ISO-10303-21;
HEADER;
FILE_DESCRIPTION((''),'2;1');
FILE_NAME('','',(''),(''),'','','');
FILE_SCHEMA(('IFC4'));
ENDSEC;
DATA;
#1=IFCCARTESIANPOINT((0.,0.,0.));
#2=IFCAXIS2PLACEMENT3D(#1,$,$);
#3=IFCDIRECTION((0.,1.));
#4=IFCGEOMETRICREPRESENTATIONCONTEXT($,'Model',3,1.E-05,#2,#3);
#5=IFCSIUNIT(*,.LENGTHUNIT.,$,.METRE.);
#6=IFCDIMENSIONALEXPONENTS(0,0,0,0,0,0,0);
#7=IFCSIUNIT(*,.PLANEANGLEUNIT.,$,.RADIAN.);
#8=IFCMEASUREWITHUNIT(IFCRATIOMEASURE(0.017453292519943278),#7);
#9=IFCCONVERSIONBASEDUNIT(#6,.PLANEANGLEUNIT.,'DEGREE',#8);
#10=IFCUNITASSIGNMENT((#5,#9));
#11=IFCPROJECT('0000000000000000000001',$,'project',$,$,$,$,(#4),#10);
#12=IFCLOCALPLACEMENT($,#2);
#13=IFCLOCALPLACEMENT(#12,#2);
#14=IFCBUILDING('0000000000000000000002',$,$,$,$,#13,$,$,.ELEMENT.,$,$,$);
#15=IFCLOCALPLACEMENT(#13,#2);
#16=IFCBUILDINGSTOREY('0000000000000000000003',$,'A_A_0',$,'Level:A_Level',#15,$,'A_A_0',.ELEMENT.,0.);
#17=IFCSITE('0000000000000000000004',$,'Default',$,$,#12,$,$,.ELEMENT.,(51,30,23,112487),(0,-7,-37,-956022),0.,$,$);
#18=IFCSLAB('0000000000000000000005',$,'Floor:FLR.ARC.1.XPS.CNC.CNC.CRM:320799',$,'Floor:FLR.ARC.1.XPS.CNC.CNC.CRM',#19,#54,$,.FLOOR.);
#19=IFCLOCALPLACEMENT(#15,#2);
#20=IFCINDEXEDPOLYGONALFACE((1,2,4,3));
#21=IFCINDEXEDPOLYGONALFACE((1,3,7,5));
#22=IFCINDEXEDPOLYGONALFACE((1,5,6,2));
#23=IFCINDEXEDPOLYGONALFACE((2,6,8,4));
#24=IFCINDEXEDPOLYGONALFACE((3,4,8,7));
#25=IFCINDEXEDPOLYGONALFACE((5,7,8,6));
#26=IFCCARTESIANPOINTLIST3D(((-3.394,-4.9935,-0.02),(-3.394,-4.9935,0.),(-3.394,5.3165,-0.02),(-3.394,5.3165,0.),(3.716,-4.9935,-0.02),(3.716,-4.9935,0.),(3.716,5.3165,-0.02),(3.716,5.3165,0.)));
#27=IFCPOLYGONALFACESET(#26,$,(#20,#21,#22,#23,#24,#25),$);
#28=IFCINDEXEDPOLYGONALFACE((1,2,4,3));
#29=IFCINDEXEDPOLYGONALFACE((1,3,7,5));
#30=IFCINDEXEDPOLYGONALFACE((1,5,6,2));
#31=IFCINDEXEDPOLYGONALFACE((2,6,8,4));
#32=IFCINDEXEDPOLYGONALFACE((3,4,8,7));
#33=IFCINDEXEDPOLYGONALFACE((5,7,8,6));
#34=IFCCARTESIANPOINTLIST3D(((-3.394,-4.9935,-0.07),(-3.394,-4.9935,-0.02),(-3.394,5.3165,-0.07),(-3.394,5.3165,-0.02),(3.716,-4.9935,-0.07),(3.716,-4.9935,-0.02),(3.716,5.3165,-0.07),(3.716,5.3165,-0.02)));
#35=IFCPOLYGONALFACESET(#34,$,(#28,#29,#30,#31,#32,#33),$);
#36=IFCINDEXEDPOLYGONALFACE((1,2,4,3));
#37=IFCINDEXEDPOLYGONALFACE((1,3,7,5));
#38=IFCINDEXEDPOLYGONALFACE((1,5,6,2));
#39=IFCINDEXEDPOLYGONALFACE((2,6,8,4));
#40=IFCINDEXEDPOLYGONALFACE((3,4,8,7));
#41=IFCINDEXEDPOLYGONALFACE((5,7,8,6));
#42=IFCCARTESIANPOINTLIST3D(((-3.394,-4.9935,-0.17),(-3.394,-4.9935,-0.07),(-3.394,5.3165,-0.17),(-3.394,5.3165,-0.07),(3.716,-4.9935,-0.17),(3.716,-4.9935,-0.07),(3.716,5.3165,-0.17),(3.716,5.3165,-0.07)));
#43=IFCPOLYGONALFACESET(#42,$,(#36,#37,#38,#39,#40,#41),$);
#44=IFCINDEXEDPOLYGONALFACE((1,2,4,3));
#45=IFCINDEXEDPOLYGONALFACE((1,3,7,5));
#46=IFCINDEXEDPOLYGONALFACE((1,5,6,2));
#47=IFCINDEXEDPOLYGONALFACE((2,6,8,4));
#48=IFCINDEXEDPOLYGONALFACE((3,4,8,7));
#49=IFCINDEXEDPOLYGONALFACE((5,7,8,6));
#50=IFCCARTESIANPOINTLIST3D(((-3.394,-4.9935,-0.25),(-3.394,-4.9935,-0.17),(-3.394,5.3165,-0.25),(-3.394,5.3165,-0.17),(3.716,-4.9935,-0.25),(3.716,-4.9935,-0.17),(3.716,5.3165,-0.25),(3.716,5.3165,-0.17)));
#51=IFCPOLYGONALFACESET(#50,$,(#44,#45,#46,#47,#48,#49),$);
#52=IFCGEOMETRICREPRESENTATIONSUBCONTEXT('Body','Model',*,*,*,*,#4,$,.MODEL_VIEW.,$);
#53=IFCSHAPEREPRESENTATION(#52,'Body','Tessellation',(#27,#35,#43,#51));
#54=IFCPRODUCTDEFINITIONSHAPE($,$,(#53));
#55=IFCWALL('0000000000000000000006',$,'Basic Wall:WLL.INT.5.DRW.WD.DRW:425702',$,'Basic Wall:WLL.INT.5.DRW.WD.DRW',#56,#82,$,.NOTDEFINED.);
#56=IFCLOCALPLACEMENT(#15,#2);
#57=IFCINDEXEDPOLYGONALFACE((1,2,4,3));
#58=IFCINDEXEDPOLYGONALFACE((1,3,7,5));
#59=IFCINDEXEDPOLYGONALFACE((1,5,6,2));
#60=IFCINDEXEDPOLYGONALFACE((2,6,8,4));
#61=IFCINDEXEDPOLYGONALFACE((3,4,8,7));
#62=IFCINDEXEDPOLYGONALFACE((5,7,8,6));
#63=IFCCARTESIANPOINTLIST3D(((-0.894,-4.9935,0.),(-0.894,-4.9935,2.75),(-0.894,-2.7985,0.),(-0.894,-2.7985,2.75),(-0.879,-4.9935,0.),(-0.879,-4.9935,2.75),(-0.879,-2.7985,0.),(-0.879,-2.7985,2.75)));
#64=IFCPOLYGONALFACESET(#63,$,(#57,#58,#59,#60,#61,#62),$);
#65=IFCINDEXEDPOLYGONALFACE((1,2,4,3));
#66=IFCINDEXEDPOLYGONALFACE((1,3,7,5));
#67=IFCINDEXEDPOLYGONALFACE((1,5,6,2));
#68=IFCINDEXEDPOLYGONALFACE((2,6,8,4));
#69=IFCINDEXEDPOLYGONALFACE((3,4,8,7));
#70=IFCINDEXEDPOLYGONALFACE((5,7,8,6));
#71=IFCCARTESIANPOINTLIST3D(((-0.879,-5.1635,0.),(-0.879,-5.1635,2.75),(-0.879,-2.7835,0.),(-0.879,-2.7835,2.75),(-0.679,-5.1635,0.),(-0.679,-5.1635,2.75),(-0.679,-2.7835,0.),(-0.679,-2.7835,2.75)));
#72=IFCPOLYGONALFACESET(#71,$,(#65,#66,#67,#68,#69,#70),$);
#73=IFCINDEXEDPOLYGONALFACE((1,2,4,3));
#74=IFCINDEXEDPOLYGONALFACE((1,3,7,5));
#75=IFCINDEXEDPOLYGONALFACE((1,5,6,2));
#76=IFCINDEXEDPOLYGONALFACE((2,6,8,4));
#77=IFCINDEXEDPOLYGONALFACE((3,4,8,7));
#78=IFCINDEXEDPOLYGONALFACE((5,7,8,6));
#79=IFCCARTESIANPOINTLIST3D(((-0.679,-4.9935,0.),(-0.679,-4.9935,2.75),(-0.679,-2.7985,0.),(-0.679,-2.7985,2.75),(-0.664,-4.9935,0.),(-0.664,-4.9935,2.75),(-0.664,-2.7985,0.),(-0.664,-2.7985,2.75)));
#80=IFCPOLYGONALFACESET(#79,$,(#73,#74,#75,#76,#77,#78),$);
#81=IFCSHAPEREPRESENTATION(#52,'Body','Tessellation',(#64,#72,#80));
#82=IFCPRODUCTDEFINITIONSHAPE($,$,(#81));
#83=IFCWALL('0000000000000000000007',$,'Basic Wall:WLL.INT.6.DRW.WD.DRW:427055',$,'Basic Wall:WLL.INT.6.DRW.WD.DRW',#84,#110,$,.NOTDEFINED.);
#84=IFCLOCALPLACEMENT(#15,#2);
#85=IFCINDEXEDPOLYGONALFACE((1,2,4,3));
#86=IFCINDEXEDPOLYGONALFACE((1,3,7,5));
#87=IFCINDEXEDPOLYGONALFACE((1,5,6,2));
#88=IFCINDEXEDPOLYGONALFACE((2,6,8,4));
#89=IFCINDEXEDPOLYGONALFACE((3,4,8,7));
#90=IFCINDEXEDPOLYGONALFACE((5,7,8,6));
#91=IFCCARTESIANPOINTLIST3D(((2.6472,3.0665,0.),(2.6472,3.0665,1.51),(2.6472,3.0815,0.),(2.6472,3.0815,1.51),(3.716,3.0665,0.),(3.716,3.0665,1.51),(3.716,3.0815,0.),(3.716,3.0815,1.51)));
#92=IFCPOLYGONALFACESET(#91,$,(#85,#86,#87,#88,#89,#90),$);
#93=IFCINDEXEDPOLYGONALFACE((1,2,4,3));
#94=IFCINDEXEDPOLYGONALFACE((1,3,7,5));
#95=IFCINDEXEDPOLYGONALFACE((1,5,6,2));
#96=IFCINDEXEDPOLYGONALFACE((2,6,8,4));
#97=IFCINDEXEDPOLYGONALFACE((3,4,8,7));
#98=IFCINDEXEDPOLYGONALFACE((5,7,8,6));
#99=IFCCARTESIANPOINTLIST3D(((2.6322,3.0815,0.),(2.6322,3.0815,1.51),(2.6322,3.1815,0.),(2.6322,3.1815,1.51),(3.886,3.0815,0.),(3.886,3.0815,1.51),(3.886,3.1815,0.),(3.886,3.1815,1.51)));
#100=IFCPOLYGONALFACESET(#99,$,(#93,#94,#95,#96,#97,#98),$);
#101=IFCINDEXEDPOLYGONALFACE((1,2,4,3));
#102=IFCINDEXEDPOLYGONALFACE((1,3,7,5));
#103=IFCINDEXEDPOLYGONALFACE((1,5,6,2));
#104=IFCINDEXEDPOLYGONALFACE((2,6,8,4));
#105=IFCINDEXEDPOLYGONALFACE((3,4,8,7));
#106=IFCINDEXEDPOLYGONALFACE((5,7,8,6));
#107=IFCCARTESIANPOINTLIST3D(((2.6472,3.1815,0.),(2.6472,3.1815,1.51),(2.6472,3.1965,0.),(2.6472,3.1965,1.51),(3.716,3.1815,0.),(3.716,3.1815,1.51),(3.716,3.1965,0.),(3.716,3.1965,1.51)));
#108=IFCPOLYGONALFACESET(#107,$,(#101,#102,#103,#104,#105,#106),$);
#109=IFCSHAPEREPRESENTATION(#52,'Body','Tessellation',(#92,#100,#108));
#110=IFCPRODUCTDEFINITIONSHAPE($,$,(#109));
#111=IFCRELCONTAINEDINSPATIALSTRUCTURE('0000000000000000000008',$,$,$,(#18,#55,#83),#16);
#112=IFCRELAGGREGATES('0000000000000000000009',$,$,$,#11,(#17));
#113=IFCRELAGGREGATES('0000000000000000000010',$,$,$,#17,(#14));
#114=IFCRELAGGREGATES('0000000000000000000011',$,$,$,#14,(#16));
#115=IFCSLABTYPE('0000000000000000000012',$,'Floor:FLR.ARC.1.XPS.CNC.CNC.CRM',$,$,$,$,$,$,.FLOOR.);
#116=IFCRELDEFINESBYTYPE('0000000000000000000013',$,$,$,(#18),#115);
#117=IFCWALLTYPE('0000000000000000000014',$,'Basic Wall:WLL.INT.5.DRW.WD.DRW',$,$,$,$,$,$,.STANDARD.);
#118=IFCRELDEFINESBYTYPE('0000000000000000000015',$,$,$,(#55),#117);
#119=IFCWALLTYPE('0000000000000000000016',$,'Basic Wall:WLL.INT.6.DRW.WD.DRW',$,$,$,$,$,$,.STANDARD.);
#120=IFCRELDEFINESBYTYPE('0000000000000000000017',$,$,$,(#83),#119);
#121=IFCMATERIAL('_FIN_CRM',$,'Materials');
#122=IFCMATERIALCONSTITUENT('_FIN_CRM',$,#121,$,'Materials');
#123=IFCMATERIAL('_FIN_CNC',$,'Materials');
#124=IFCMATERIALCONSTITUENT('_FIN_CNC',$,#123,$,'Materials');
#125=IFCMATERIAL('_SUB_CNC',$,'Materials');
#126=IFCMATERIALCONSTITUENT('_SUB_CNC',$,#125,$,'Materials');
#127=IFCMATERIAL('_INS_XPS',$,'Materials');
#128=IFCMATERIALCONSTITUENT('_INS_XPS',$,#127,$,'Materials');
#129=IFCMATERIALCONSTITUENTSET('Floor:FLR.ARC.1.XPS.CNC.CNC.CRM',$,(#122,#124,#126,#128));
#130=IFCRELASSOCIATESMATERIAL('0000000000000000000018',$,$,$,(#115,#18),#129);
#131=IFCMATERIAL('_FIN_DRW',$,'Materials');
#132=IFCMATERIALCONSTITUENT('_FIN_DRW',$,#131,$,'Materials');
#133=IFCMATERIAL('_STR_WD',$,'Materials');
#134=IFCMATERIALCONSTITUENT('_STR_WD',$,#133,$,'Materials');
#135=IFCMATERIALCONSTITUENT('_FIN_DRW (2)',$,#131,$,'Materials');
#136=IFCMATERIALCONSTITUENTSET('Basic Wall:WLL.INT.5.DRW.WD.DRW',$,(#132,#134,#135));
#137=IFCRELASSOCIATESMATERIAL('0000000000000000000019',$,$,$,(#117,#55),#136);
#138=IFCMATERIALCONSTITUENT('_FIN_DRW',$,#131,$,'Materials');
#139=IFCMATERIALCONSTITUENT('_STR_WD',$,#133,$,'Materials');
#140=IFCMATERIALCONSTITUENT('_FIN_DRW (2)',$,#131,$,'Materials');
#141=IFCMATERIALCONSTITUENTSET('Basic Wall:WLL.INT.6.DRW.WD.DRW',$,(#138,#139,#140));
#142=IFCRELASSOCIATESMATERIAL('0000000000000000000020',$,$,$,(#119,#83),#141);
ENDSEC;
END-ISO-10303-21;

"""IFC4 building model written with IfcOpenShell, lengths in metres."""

from ifc_helpers import new_model, entity, si_unit, converted_unit, direction, frame, origin, place, context, subcontext, project, spatial, indexed_curve, outline, extrude, material, constituent, constituent_set, type_object, element, save


model = new_model("IFC4")

# Units and contexts
model_context = context("Model", 3, precision=1e-05, world=origin(), true_north=direction((0.0, 1.0)))
body_context = subcontext(model_context, "Body", "Model", "MODEL_VIEW")
ifc_project = project(units=[si_unit("LENGTHUNIT", "METRE"), converted_unit("PLANEANGLEUNIT", "DEGREE", entity("IfcRatioMeasure", 0.017453292519943278), si_unit("PLANEANGLEUNIT", "RADIAN"), dimensions=[0, 0, 0, 0, 0, 0, 0])], contexts=[model_context])

# Site, building, storey
site_placement = place(None, origin())
site = spatial("IfcSite", under=ifc_project, at=site_placement, Name="Default", CompositionType="ELEMENT", RefLatitude=(51, 30, 23, 112487), RefLongitude=(0, -7, -37, -956022), RefElevation=0.0)
building_placement = place(site_placement, origin())
building = spatial("IfcBuilding", under=site, at=building_placement, CompositionType="ELEMENT")
storey_placement = place(building_placement, origin())
storey = spatial("IfcBuildingStorey", under=building, at=storey_placement, Name="A_A_0", ObjectType="Level:A_Level", LongName="A_A_0", CompositionType="ELEMENT", Elevation=0.0)

# Slab
ifc_material_1 = material(Name="_FIN_CRM", Category="Materials")
ifc_constituent_1 = constituent(ifc_material_1, Name="_FIN_CRM", Category="Materials")
ifc_material_2 = material(Name="_FIN_CNC", Category="Materials")
ifc_constituent_2 = constituent(ifc_material_2, Name="_FIN_CNC", Category="Materials")
ifc_material_3 = material(Name="_SUB_CNC", Category="Materials")
ifc_constituent_3 = constituent(ifc_material_3, Name="_SUB_CNC", Category="Materials")
ifc_material_4 = material(Name="_INS_XPS", Category="Materials")
ifc_constituent_4 = constituent(ifc_material_4, Name="_INS_XPS", Category="Materials")
ifc_constituent_set_1 = constituent_set(constituents=[ifc_constituent_1, ifc_constituent_2, ifc_constituent_3, ifc_constituent_4], Name="Floor:FLR.ARC.1.XPS.CNC.CNC.CRM")
slab_type = type_object("IfcSlabType", Name="Floor:FLR.ARC.1.XPS.CNC.CNC.CRM", PredefinedType="FLOOR", material=ifc_constituent_set_1)
slab_placement = place(storey_placement, origin())
element("IfcSlab", 1, at=slab_placement, inside=storey, type_object=slab_type, material=ifc_constituent_set_1, Name="Floor:FLR.ARC.1.XPS.CNC.CNC.CRM:320799", ObjectType="Floor:FLR.ARC.1.XPS.CNC.CNC.CRM", PredefinedType="FLOOR", context=body_context, shape_type="SweptSolid", body=[
    extrude(outline(indexed_curve([(-5.155, -3.555), (5.155, -3.555), (5.155, 3.555), (-5.155, 3.555), (-5.155, -3.555)], self_intersect=False)), frame((0.161, 0.1615, -0.02), z_axis=(0.0, 0.0, 1.0), x_axis=(0.0, 1.0, 0.0)), (0.0, 0.0, 1.0), 0.02),
    extrude(outline(indexed_curve([(-5.155, -3.555), (5.155, -3.555), (5.155, 3.555), (-5.155, 3.555), (-5.155, -3.555)], self_intersect=False)), frame((0.161, 0.1615, -0.07), z_axis=(0.0, 0.0, 1.0), x_axis=(0.0, 1.0, 0.0)), (0.0, 0.0, 1.0), 0.05),
    extrude(outline(indexed_curve([(-5.155, -3.555), (5.155, -3.555), (5.155, 3.555), (-5.155, 3.555), (-5.155, -3.555)], self_intersect=False)), frame((0.161, 0.1615, -0.17), z_axis=(0.0, 0.0, 1.0), x_axis=(0.0, 1.0, 0.0)), (0.0, 0.0, 1.0), 0.1),
    extrude(outline(indexed_curve([(-5.155, -3.555), (5.155, -3.555), (5.155, 3.555), (-5.155, 3.555), (-5.155, -3.555)], self_intersect=False)), frame((0.161, 0.1615, -0.25), z_axis=(0.0, 0.0, 1.0), x_axis=(0.0, 1.0, 0.0)), (0.0, 0.0, 1.0), 0.08),
])

# Wall
ifc_material_5 = material(Name="_FIN_DRW", Category="Materials")
ifc_constituent_5 = constituent(ifc_material_5, Name="_FIN_DRW", Category="Materials")
ifc_material_6 = material(Name="_STR_WD", Category="Materials")
ifc_constituent_6 = constituent(ifc_material_6, Name="_STR_WD", Category="Materials")
ifc_constituent_7 = constituent(ifc_material_5, Name="_FIN_DRW (2)", Category="Materials")
ifc_constituent_set_2 = constituent_set(constituents=[ifc_constituent_5, ifc_constituent_6, ifc_constituent_7], Name="Basic Wall:WLL.INT.5.DRW.WD.DRW")
wall_type_1 = type_object("IfcWallType", Name="Basic Wall:WLL.INT.5.DRW.WD.DRW", PredefinedType="STANDARD", material=ifc_constituent_set_2)
wall_1_placement = place(storey_placement, frame((-0.779, -2.7985, 0.0), z_axis=(0.0, 0.0, 1.0), x_axis=(0.0, -1.0, 0.0)))
element("IfcWall", 2, at=wall_1_placement, inside=storey, type_object=wall_type_1, material=ifc_constituent_set_2, Name="Basic Wall:WLL.INT.5.DRW.WD.DRW:425702", ObjectType="Basic Wall:WLL.INT.5.DRW.WD.DRW", PredefinedType="NOTDEFINED", context=body_context, shape_type="SweptSolid", body=[
    extrude(outline(indexed_curve([(-0.0075, -1.0975), (0.0075, -1.0975), (0.0075, 1.0975), (-0.0075, 1.0975), (-0.0075, -1.0975)], self_intersect=False)), frame((1.0975, -0.1075, 0.0), z_axis=(0.0, 0.0, 1.0), x_axis=(0.0, 1.0, 0.0)), (0.0, 0.0, 1.0), 2.75),
    extrude(outline(indexed_curve([(-1.19, -0.1), (1.19, -0.1), (1.19, 0.1), (-1.19, 0.1), (-1.19, -0.1)], self_intersect=False)), frame((1.175, 0.0, 0.0)), (0.0, 0.0, 1.0), 2.75),
    extrude(outline(indexed_curve([(-0.0075, -1.0975), (0.0075, -1.0975), (0.0075, 1.0975), (-0.0075, 1.0975), (-0.0075, -1.0975)], self_intersect=False)), frame((1.0975, 0.1075, 0.0), z_axis=(0.0, 0.0, 1.0), x_axis=(0.0, -1.0, 0.0)), (0.0, 0.0, 1.0), 2.75),
])

# Shared definitions
ifc_constituent_8 = constituent(ifc_material_5, Name="_FIN_DRW", Category="Materials")
ifc_constituent_9 = constituent(ifc_material_6, Name="_STR_WD", Category="Materials")
ifc_constituent_10 = constituent(ifc_material_5, Name="_FIN_DRW (2)", Category="Materials")
ifc_constituent_set_3 = constituent_set(constituents=[ifc_constituent_8, ifc_constituent_9, ifc_constituent_10], Name="Basic Wall:WLL.INT.6.DRW.WD.DRW")
wall_type_2 = type_object("IfcWallType", Name="Basic Wall:WLL.INT.6.DRW.WD.DRW", PredefinedType="STANDARD", material=ifc_constituent_set_3)

# Wall
wall_2_placement = place(storey_placement, frame((2.6472, 3.1315, 0.0)))
element("IfcWall", 3, at=wall_2_placement, inside=storey, type_object=wall_type_2, material=ifc_constituent_set_3, Name="Basic Wall:WLL.INT.6.DRW.WD.DRW:427055", ObjectType="Basic Wall:WLL.INT.6.DRW.WD.DRW", PredefinedType="NOTDEFINED", context=body_context, shape_type="SweptSolid", body=[
    extrude(outline(indexed_curve([(-0.0075, -0.5344), (0.0075, -0.5344), (0.0075, 0.5344), (-0.0075, 0.5344), (-0.0075, -0.5344)], self_intersect=False)), frame((0.5344, -0.0575, 0.0), z_axis=(0.0, 0.0, 1.0), x_axis=(0.0, 1.0, 0.0)), (0.0, 0.0, 1.0), 1.51),
    extrude(outline(indexed_curve([(-0.6269, -0.05), (0.6269, -0.05), (0.6269, 0.05), (-0.6269, 0.05), (-0.6269, -0.05)], self_intersect=False)), frame((0.6119, 0.0, 0.0)), (0.0, 0.0, 1.0), 1.51),
    extrude(outline(indexed_curve([(-0.0075, -0.5344), (0.0075, -0.5344), (0.0075, 0.5344), (-0.0075, 0.5344), (-0.0075, -0.5344)], self_intersect=False)), frame((0.5344, 0.0575, 0.0), z_axis=(0.0, 0.0, 1.0), x_axis=(0.0, -1.0, 0.0)), (0.0, 0.0, 1.0), 1.51),
])

save(model, "model.ifc")
